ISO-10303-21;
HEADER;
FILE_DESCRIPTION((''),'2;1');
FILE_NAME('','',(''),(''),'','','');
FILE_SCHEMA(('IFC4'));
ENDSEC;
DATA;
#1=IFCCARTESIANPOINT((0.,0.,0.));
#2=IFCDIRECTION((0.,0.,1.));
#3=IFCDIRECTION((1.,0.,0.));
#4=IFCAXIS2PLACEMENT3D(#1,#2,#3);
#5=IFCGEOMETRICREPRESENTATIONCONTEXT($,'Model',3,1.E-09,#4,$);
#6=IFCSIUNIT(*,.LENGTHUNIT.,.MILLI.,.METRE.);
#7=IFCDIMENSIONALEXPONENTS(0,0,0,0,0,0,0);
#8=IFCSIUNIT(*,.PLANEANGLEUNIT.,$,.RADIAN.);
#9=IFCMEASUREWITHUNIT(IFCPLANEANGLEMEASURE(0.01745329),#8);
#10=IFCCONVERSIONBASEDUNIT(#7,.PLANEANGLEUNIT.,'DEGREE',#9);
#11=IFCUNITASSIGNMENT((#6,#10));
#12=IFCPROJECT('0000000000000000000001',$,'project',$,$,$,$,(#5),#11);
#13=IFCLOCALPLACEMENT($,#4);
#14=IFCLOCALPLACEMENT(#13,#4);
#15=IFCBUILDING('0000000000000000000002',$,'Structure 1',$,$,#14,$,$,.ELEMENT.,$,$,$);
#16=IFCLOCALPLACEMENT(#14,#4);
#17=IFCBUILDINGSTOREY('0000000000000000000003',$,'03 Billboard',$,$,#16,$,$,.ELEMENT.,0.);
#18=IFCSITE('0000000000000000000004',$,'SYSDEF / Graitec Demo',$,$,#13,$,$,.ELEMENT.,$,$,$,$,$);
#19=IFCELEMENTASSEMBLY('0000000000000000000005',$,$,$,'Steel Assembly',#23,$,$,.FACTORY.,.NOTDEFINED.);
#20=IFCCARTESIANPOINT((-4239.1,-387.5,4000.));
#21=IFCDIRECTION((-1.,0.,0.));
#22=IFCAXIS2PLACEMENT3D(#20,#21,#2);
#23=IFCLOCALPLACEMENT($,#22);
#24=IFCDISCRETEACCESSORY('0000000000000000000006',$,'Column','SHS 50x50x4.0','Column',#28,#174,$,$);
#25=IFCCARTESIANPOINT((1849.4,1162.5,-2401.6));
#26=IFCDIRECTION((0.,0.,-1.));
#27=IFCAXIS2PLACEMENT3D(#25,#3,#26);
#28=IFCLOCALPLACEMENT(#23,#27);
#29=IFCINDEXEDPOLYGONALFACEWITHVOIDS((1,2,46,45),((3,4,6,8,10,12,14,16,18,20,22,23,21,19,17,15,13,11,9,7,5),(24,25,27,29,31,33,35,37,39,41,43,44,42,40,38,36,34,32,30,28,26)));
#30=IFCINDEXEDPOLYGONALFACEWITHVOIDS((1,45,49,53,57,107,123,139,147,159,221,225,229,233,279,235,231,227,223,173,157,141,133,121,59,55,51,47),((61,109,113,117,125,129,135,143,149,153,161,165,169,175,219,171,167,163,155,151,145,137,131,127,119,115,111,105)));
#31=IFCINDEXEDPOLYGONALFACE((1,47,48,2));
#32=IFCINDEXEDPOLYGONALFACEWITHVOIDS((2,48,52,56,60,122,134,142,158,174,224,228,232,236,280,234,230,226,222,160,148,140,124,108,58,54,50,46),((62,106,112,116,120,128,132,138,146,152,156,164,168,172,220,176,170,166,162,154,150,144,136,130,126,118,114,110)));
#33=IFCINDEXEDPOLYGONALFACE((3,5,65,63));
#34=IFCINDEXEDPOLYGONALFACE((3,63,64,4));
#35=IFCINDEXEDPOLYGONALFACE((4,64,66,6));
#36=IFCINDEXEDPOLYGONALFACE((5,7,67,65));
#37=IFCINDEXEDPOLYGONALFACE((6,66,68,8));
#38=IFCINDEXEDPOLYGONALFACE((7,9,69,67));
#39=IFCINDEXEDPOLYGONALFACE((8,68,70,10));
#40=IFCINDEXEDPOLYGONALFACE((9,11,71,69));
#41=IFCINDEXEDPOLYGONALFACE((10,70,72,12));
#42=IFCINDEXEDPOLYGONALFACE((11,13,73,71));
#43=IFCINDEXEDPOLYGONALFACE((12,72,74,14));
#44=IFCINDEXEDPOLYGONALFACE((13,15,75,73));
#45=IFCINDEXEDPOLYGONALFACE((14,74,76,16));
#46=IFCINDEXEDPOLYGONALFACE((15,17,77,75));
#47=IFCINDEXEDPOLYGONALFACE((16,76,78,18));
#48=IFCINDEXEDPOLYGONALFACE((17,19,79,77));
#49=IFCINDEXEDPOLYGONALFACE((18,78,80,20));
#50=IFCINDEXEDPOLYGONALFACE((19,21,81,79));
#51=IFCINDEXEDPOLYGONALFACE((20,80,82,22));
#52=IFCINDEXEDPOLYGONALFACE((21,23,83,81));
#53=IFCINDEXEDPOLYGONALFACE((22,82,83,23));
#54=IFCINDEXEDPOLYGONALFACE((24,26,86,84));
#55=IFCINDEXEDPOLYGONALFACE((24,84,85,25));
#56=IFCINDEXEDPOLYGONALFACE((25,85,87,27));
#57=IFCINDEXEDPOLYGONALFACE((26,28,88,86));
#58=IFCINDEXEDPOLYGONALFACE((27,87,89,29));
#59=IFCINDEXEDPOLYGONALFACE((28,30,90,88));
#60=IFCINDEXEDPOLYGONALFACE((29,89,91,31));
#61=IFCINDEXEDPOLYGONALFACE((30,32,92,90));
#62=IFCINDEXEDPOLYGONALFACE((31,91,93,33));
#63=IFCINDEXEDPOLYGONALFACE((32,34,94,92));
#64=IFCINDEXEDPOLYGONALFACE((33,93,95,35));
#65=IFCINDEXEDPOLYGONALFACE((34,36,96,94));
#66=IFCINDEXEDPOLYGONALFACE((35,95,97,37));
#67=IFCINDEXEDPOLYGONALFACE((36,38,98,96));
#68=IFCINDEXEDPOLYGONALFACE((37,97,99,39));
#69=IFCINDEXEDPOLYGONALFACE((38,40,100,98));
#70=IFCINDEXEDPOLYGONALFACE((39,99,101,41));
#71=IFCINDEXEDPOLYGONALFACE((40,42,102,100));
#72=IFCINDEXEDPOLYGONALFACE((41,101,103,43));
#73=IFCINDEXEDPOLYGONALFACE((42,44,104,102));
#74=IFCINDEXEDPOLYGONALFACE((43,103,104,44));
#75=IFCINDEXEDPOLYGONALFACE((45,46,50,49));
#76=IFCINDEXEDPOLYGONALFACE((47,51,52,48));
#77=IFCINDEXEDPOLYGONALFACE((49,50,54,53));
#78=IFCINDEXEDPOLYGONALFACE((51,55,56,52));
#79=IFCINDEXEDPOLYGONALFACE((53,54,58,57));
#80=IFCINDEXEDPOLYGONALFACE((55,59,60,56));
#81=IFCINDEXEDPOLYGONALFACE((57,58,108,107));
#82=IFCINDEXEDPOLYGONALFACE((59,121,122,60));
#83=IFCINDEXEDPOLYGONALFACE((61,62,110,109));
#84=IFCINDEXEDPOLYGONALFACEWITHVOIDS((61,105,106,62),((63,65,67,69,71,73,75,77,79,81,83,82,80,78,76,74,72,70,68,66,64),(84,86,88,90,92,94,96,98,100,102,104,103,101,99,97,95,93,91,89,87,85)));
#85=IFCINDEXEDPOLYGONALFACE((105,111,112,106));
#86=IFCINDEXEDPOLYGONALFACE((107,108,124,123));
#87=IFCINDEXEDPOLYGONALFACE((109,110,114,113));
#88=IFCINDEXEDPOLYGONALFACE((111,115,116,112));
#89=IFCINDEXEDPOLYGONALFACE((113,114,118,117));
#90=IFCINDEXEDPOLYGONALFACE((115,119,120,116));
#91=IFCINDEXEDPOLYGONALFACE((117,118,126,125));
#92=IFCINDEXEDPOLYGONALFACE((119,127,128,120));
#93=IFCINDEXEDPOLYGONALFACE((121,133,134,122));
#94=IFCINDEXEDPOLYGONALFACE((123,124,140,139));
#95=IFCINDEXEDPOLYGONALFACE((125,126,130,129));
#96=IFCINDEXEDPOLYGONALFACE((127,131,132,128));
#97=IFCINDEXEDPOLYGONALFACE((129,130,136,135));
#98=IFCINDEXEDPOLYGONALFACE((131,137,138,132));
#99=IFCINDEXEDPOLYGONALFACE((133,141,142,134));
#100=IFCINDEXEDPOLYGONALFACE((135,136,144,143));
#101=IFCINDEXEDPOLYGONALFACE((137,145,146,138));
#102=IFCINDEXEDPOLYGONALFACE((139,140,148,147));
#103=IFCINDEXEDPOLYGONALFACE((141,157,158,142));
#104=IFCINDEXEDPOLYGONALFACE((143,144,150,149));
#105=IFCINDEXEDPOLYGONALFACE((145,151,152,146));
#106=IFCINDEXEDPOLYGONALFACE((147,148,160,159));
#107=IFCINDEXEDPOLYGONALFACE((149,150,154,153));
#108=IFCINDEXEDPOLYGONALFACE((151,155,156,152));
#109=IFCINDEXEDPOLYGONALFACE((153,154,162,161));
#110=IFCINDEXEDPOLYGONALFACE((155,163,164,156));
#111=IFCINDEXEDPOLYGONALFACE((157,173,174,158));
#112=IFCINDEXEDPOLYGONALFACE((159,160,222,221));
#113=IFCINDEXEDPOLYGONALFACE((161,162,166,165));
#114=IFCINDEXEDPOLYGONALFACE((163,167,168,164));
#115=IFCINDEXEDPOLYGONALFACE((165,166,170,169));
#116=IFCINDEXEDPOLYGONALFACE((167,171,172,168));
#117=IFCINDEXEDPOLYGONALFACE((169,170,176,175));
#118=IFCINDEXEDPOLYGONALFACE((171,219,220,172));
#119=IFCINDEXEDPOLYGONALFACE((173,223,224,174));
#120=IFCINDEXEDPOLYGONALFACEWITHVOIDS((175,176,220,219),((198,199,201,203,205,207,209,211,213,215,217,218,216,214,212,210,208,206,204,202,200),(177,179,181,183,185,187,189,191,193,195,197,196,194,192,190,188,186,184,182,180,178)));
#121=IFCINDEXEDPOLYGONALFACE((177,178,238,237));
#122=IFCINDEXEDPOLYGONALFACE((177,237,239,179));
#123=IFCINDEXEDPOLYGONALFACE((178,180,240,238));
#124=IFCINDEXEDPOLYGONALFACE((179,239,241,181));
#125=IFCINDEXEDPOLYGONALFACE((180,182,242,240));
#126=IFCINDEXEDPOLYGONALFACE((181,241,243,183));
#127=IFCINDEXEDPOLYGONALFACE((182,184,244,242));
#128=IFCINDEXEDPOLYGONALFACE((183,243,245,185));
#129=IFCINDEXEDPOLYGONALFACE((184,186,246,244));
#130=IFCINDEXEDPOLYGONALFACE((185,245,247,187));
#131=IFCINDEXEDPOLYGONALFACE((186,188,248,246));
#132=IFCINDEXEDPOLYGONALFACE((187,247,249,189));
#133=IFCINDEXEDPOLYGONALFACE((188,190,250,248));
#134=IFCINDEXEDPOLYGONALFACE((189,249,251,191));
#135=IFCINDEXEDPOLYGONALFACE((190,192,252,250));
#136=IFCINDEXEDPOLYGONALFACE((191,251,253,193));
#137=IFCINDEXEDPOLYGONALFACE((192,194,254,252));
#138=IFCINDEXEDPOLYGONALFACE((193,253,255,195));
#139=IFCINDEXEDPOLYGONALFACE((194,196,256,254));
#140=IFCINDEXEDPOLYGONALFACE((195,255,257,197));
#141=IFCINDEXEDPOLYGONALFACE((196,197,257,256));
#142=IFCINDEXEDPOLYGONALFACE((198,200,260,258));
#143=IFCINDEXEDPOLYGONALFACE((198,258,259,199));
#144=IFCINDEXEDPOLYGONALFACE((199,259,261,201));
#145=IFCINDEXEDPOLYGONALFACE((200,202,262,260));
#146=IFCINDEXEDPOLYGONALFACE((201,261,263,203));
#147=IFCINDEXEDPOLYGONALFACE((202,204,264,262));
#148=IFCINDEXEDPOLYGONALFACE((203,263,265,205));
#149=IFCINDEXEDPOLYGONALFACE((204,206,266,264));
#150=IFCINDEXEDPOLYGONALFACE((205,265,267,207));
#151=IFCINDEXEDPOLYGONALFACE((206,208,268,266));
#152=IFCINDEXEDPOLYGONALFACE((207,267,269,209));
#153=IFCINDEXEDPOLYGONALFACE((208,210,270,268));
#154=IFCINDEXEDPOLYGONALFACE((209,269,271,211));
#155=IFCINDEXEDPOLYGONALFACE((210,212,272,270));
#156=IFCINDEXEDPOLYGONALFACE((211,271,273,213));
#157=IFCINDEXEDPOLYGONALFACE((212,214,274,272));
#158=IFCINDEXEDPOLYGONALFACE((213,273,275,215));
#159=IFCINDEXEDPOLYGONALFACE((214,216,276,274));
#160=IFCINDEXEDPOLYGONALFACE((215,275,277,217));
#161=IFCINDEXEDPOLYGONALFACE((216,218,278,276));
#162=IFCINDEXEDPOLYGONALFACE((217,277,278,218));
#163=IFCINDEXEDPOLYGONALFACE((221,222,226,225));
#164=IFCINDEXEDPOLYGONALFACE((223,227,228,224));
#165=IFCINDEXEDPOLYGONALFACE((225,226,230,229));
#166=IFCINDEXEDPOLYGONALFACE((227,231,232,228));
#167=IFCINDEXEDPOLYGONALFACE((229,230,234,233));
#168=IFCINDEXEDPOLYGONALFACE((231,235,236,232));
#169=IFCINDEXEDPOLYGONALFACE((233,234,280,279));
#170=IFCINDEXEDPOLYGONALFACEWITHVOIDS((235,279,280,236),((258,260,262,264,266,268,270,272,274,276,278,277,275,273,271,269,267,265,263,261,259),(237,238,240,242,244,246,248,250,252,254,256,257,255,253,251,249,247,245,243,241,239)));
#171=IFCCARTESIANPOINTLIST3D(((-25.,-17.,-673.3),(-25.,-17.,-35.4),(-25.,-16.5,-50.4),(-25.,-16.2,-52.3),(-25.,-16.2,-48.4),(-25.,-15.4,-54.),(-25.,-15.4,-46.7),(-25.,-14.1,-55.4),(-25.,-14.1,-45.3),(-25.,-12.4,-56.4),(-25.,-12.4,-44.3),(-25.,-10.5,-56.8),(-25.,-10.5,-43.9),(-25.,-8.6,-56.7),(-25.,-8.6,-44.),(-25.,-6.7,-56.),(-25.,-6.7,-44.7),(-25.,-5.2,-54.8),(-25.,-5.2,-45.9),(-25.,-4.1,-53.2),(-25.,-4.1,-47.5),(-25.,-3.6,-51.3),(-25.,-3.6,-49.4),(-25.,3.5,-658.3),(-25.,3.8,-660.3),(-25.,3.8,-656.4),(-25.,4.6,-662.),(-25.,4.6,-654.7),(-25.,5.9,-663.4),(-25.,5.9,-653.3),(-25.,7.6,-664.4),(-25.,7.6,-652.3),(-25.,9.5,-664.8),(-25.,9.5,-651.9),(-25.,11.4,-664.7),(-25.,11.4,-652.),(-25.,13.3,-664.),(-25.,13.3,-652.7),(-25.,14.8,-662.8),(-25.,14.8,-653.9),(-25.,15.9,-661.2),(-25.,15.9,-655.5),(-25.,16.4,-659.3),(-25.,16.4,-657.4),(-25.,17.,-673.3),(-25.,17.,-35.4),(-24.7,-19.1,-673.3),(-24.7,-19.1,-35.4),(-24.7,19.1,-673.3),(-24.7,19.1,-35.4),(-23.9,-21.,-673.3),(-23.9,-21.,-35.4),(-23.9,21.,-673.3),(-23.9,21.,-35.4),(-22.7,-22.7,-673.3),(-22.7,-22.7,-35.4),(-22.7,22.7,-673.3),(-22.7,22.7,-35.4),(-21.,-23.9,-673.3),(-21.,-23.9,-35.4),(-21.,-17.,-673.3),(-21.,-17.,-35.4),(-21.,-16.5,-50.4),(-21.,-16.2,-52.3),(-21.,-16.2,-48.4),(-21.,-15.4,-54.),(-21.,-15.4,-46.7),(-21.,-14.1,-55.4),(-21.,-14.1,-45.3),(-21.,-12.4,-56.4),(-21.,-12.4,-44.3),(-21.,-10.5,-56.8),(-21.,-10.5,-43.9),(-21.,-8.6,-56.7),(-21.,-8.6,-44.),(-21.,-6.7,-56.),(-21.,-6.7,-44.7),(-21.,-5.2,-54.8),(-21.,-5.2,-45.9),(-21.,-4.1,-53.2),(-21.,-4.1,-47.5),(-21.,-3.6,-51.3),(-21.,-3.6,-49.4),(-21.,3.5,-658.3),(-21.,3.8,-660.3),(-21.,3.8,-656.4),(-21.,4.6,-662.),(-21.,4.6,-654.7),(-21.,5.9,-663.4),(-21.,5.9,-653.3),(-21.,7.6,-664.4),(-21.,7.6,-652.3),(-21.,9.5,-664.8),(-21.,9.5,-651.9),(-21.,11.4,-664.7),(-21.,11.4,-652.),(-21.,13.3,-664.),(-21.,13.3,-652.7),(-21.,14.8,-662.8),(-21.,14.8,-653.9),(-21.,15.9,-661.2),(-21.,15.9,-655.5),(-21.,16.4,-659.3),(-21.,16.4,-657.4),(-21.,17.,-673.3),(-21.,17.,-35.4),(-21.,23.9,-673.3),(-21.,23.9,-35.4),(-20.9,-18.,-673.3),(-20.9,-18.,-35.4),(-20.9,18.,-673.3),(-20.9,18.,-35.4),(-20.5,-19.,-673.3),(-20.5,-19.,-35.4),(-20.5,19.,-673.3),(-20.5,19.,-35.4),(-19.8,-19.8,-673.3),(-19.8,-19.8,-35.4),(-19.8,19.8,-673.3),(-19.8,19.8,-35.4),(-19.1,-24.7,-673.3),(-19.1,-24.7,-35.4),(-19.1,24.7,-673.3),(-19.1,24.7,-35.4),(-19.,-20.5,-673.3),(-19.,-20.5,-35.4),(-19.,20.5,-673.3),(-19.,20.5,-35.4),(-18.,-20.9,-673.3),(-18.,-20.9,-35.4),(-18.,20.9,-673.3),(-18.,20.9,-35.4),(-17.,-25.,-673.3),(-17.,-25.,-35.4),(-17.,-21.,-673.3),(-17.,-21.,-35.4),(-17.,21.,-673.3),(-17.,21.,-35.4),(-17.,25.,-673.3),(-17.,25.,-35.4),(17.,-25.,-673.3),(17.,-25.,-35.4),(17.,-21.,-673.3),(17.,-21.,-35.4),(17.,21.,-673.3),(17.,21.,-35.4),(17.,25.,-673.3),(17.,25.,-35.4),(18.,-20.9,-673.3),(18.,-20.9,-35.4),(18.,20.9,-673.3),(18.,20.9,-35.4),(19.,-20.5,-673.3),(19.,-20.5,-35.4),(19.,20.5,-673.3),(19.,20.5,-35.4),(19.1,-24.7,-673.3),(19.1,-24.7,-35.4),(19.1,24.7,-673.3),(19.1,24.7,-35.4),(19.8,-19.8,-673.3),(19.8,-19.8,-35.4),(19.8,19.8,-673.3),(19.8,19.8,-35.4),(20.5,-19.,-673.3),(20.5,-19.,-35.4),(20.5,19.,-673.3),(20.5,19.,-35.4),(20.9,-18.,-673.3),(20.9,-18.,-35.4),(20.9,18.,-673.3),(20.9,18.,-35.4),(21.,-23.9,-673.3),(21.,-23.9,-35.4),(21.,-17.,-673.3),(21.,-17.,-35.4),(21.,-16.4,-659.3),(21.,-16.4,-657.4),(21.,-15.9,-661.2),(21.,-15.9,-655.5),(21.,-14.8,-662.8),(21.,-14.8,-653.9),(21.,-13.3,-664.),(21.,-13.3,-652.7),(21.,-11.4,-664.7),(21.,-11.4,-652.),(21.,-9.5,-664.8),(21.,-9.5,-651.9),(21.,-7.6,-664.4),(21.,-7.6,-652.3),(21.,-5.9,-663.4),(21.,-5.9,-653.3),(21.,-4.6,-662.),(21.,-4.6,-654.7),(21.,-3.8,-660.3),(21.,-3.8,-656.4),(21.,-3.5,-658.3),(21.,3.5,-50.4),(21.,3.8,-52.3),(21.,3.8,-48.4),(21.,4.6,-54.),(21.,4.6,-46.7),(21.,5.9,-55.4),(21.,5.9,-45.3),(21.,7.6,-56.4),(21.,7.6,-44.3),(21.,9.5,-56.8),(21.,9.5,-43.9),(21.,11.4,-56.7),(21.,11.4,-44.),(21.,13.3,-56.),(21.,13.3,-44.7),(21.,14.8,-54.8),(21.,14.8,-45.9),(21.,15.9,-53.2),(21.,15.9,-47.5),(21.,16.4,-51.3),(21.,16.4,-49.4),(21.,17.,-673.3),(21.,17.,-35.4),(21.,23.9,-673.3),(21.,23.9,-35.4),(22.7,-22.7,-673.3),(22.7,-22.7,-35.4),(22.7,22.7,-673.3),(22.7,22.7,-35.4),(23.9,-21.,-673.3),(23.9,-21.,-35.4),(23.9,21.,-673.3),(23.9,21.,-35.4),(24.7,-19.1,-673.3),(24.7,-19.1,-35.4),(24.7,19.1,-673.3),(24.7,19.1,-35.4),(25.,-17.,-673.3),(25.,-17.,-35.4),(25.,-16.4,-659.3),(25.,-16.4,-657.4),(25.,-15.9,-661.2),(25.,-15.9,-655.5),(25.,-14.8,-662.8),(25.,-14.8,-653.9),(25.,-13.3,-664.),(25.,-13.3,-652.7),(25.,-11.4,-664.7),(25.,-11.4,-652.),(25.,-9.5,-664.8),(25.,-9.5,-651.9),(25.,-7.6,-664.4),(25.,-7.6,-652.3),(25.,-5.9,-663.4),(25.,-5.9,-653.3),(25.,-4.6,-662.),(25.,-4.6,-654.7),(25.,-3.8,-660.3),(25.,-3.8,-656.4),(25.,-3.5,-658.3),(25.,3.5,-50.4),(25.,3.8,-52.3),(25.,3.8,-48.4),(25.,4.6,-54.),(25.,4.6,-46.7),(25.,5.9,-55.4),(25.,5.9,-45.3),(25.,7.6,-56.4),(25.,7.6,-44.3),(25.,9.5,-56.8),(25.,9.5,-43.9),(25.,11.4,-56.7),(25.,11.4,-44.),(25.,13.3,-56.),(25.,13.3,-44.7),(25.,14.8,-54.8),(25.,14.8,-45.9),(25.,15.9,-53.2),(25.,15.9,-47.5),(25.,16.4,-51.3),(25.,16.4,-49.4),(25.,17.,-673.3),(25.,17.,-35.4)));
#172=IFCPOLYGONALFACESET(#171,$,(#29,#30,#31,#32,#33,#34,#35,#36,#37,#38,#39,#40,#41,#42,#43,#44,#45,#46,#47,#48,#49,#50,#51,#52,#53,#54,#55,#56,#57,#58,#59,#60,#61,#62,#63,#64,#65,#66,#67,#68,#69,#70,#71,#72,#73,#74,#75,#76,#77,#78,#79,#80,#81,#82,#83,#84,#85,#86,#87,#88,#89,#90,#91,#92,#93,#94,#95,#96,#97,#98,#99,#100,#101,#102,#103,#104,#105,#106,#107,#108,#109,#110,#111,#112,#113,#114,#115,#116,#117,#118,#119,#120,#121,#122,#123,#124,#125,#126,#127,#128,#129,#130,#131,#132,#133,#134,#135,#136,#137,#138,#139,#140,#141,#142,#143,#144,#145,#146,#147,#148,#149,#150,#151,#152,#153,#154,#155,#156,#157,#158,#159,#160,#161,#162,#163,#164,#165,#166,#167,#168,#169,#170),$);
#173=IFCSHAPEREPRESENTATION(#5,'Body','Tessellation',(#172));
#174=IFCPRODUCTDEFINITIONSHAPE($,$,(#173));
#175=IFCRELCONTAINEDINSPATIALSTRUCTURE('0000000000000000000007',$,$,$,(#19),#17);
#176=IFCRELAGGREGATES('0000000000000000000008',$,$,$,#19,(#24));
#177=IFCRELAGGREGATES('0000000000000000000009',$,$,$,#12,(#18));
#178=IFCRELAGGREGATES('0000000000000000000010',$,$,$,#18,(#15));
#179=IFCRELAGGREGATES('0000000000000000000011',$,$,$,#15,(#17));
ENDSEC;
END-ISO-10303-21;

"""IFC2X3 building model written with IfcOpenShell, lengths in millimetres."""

from ifc_helpers import new_model, entity, si_unit, converted_unit, frame, frame_2d, origin, origin_with_axes, origin_2d, origin_2d_with_axis, place, context, project, spatial, hollow_rectangle, circle, extrude, clip, halfspace, element, aggregate, save


model = new_model("IFC2X3")

# Units and contexts
model_context = context("Model", 3, precision=1e-09, world=origin_with_axes())
ifc_project = project(units=[si_unit("LENGTHUNIT", "METRE", prefix="MILLI"), converted_unit("PLANEANGLEUNIT", "DEGREE", entity("IfcPlaneAngleMeasure", 0.01745329), si_unit("PLANEANGLEUNIT", "RADIAN"), dimensions=[0, 0, 0, 0, 0, 0, 0])], contexts=[model_context])

# Site, building, storey
site_placement = place(None, origin_with_axes())
site = spatial("IfcSite", under=ifc_project, at=site_placement, Name="SYSDEF / Graitec Demo", CompositionType="ELEMENT")
building_placement = place(site_placement, origin_with_axes())
building = spatial("IfcBuilding", under=site, at=building_placement, Name="Structure 1", CompositionType="ELEMENT")
storey_placement = place(building_placement, origin_with_axes())
storey = spatial("IfcBuildingStorey", under=building, at=storey_placement, Name="03 Billboard", CompositionType="ELEMENT", Elevation=0.0)

# Element assembly, discrete accessory, openings
assembly_1_placement = place(None, frame((-4239.1, -387.5, 4000.0), z_axis=(-1.0, 0.0, 0.0), x_axis=(0.0, 0.0, 1.0)))
assembly_1 = element("IfcElementAssembly", 1, at=assembly_1_placement, inside=storey, ObjectType="Steel Assembly", AssemblyPlace="FACTORY", PredefinedType="NOTDEFINED")
discrete_accessory_1_placement = place(assembly_1_placement, frame((1849.4, 1162.5, -2401.6), z_axis=(1.0, 0.0, 0.0), x_axis=(0.0, 0.0, -1.0)))
discrete_accessory_1 = element("IfcDiscreteAccessory", 2, at=discrete_accessory_1_placement, Name="Column", Description="SHS 50x50x4.0", ObjectType="Column", context=model_context, shape_type="Clipping", body=[
    clip(clip(extrude(hollow_rectangle(XDim=50.0, YDim=50.0, WallThickness=4.0, InnerFilletRadius=4.0, OuterFilletRadius=8.0, at=origin_2d()), origin(), (0.0, 0.0, -1.0), 733.7), halfspace(frame((1837.5, -775.0, -673.3), z_axis=(0.0, 0.0, 1.0), x_axis=(1.0, 0.0, 0.0)), True)), halfspace(frame((1837.5, -775.0, -35.4), z_axis=(0.0, 0.0, -1.0), x_axis=(-1.0, 0.0, 0.0)), True)),
])
opening_1_placement = place(discrete_accessory_1_placement, frame((-25.5, 16.5, -658.3), z_axis=(-1.0, 0.0, 0.0), x_axis=(0.0, -1.0, 0.0)))
element("IfcOpeningElement", 3, at=opening_1_placement, cuts=discrete_accessory_1, ObjectType="Opening", context=model_context, shape_type="SweptSolid", body=[
    extrude(circle(Radius=6.5, at=frame_2d((6.5, 0.0), x_axis=(1.0, 0.0))), origin(), (0.0, 0.0, -1.0), 5.0),
])
opening_2_placement = place(discrete_accessory_1_placement, frame((20.5, -10.0, -658.3), z_axis=(1.0, 0.0, 0.0), x_axis=(0.0, 1.0, 0.0)))
element("IfcOpeningElement", 4, at=opening_2_placement, cuts=discrete_accessory_1, ObjectType="Opening", context=model_context, shape_type="SweptSolid", body=[
    extrude(circle(Radius=6.5, at=origin_2d_with_axis()), origin(), (0.0, 0.0, 1.0), 5.0),
])
opening_3_placement = place(discrete_accessory_1_placement, frame((-25.5, -16.5, -50.4), z_axis=(-1.0, 0.0, 0.0), x_axis=(0.0, -1.0, 0.0)))
element("IfcOpeningElement", 5, at=opening_3_placement, cuts=discrete_accessory_1, ObjectType="Opening", context=model_context, shape_type="SweptSolid", body=[
    extrude(circle(Radius=6.5, at=frame_2d((-6.5, 0.0), x_axis=(1.0, 0.0))), origin(), (0.0, 0.0, -1.0), 5.0),
])
opening_4_placement = place(discrete_accessory_1_placement, frame((20.5, 10.0, -50.4), z_axis=(1.0, 0.0, 0.0), x_axis=(0.0, -1.0, 0.0)))
element("IfcOpeningElement", 6, at=opening_4_placement, cuts=discrete_accessory_1, ObjectType="Opening", context=model_context, shape_type="SweptSolid", body=[
    extrude(circle(Radius=6.5, at=origin_2d_with_axis()), origin(), (0.0, 0.0, 1.0), 5.0),
])
aggregate(assembly_1, [discrete_accessory_1])

save(model, "model.ifc")
